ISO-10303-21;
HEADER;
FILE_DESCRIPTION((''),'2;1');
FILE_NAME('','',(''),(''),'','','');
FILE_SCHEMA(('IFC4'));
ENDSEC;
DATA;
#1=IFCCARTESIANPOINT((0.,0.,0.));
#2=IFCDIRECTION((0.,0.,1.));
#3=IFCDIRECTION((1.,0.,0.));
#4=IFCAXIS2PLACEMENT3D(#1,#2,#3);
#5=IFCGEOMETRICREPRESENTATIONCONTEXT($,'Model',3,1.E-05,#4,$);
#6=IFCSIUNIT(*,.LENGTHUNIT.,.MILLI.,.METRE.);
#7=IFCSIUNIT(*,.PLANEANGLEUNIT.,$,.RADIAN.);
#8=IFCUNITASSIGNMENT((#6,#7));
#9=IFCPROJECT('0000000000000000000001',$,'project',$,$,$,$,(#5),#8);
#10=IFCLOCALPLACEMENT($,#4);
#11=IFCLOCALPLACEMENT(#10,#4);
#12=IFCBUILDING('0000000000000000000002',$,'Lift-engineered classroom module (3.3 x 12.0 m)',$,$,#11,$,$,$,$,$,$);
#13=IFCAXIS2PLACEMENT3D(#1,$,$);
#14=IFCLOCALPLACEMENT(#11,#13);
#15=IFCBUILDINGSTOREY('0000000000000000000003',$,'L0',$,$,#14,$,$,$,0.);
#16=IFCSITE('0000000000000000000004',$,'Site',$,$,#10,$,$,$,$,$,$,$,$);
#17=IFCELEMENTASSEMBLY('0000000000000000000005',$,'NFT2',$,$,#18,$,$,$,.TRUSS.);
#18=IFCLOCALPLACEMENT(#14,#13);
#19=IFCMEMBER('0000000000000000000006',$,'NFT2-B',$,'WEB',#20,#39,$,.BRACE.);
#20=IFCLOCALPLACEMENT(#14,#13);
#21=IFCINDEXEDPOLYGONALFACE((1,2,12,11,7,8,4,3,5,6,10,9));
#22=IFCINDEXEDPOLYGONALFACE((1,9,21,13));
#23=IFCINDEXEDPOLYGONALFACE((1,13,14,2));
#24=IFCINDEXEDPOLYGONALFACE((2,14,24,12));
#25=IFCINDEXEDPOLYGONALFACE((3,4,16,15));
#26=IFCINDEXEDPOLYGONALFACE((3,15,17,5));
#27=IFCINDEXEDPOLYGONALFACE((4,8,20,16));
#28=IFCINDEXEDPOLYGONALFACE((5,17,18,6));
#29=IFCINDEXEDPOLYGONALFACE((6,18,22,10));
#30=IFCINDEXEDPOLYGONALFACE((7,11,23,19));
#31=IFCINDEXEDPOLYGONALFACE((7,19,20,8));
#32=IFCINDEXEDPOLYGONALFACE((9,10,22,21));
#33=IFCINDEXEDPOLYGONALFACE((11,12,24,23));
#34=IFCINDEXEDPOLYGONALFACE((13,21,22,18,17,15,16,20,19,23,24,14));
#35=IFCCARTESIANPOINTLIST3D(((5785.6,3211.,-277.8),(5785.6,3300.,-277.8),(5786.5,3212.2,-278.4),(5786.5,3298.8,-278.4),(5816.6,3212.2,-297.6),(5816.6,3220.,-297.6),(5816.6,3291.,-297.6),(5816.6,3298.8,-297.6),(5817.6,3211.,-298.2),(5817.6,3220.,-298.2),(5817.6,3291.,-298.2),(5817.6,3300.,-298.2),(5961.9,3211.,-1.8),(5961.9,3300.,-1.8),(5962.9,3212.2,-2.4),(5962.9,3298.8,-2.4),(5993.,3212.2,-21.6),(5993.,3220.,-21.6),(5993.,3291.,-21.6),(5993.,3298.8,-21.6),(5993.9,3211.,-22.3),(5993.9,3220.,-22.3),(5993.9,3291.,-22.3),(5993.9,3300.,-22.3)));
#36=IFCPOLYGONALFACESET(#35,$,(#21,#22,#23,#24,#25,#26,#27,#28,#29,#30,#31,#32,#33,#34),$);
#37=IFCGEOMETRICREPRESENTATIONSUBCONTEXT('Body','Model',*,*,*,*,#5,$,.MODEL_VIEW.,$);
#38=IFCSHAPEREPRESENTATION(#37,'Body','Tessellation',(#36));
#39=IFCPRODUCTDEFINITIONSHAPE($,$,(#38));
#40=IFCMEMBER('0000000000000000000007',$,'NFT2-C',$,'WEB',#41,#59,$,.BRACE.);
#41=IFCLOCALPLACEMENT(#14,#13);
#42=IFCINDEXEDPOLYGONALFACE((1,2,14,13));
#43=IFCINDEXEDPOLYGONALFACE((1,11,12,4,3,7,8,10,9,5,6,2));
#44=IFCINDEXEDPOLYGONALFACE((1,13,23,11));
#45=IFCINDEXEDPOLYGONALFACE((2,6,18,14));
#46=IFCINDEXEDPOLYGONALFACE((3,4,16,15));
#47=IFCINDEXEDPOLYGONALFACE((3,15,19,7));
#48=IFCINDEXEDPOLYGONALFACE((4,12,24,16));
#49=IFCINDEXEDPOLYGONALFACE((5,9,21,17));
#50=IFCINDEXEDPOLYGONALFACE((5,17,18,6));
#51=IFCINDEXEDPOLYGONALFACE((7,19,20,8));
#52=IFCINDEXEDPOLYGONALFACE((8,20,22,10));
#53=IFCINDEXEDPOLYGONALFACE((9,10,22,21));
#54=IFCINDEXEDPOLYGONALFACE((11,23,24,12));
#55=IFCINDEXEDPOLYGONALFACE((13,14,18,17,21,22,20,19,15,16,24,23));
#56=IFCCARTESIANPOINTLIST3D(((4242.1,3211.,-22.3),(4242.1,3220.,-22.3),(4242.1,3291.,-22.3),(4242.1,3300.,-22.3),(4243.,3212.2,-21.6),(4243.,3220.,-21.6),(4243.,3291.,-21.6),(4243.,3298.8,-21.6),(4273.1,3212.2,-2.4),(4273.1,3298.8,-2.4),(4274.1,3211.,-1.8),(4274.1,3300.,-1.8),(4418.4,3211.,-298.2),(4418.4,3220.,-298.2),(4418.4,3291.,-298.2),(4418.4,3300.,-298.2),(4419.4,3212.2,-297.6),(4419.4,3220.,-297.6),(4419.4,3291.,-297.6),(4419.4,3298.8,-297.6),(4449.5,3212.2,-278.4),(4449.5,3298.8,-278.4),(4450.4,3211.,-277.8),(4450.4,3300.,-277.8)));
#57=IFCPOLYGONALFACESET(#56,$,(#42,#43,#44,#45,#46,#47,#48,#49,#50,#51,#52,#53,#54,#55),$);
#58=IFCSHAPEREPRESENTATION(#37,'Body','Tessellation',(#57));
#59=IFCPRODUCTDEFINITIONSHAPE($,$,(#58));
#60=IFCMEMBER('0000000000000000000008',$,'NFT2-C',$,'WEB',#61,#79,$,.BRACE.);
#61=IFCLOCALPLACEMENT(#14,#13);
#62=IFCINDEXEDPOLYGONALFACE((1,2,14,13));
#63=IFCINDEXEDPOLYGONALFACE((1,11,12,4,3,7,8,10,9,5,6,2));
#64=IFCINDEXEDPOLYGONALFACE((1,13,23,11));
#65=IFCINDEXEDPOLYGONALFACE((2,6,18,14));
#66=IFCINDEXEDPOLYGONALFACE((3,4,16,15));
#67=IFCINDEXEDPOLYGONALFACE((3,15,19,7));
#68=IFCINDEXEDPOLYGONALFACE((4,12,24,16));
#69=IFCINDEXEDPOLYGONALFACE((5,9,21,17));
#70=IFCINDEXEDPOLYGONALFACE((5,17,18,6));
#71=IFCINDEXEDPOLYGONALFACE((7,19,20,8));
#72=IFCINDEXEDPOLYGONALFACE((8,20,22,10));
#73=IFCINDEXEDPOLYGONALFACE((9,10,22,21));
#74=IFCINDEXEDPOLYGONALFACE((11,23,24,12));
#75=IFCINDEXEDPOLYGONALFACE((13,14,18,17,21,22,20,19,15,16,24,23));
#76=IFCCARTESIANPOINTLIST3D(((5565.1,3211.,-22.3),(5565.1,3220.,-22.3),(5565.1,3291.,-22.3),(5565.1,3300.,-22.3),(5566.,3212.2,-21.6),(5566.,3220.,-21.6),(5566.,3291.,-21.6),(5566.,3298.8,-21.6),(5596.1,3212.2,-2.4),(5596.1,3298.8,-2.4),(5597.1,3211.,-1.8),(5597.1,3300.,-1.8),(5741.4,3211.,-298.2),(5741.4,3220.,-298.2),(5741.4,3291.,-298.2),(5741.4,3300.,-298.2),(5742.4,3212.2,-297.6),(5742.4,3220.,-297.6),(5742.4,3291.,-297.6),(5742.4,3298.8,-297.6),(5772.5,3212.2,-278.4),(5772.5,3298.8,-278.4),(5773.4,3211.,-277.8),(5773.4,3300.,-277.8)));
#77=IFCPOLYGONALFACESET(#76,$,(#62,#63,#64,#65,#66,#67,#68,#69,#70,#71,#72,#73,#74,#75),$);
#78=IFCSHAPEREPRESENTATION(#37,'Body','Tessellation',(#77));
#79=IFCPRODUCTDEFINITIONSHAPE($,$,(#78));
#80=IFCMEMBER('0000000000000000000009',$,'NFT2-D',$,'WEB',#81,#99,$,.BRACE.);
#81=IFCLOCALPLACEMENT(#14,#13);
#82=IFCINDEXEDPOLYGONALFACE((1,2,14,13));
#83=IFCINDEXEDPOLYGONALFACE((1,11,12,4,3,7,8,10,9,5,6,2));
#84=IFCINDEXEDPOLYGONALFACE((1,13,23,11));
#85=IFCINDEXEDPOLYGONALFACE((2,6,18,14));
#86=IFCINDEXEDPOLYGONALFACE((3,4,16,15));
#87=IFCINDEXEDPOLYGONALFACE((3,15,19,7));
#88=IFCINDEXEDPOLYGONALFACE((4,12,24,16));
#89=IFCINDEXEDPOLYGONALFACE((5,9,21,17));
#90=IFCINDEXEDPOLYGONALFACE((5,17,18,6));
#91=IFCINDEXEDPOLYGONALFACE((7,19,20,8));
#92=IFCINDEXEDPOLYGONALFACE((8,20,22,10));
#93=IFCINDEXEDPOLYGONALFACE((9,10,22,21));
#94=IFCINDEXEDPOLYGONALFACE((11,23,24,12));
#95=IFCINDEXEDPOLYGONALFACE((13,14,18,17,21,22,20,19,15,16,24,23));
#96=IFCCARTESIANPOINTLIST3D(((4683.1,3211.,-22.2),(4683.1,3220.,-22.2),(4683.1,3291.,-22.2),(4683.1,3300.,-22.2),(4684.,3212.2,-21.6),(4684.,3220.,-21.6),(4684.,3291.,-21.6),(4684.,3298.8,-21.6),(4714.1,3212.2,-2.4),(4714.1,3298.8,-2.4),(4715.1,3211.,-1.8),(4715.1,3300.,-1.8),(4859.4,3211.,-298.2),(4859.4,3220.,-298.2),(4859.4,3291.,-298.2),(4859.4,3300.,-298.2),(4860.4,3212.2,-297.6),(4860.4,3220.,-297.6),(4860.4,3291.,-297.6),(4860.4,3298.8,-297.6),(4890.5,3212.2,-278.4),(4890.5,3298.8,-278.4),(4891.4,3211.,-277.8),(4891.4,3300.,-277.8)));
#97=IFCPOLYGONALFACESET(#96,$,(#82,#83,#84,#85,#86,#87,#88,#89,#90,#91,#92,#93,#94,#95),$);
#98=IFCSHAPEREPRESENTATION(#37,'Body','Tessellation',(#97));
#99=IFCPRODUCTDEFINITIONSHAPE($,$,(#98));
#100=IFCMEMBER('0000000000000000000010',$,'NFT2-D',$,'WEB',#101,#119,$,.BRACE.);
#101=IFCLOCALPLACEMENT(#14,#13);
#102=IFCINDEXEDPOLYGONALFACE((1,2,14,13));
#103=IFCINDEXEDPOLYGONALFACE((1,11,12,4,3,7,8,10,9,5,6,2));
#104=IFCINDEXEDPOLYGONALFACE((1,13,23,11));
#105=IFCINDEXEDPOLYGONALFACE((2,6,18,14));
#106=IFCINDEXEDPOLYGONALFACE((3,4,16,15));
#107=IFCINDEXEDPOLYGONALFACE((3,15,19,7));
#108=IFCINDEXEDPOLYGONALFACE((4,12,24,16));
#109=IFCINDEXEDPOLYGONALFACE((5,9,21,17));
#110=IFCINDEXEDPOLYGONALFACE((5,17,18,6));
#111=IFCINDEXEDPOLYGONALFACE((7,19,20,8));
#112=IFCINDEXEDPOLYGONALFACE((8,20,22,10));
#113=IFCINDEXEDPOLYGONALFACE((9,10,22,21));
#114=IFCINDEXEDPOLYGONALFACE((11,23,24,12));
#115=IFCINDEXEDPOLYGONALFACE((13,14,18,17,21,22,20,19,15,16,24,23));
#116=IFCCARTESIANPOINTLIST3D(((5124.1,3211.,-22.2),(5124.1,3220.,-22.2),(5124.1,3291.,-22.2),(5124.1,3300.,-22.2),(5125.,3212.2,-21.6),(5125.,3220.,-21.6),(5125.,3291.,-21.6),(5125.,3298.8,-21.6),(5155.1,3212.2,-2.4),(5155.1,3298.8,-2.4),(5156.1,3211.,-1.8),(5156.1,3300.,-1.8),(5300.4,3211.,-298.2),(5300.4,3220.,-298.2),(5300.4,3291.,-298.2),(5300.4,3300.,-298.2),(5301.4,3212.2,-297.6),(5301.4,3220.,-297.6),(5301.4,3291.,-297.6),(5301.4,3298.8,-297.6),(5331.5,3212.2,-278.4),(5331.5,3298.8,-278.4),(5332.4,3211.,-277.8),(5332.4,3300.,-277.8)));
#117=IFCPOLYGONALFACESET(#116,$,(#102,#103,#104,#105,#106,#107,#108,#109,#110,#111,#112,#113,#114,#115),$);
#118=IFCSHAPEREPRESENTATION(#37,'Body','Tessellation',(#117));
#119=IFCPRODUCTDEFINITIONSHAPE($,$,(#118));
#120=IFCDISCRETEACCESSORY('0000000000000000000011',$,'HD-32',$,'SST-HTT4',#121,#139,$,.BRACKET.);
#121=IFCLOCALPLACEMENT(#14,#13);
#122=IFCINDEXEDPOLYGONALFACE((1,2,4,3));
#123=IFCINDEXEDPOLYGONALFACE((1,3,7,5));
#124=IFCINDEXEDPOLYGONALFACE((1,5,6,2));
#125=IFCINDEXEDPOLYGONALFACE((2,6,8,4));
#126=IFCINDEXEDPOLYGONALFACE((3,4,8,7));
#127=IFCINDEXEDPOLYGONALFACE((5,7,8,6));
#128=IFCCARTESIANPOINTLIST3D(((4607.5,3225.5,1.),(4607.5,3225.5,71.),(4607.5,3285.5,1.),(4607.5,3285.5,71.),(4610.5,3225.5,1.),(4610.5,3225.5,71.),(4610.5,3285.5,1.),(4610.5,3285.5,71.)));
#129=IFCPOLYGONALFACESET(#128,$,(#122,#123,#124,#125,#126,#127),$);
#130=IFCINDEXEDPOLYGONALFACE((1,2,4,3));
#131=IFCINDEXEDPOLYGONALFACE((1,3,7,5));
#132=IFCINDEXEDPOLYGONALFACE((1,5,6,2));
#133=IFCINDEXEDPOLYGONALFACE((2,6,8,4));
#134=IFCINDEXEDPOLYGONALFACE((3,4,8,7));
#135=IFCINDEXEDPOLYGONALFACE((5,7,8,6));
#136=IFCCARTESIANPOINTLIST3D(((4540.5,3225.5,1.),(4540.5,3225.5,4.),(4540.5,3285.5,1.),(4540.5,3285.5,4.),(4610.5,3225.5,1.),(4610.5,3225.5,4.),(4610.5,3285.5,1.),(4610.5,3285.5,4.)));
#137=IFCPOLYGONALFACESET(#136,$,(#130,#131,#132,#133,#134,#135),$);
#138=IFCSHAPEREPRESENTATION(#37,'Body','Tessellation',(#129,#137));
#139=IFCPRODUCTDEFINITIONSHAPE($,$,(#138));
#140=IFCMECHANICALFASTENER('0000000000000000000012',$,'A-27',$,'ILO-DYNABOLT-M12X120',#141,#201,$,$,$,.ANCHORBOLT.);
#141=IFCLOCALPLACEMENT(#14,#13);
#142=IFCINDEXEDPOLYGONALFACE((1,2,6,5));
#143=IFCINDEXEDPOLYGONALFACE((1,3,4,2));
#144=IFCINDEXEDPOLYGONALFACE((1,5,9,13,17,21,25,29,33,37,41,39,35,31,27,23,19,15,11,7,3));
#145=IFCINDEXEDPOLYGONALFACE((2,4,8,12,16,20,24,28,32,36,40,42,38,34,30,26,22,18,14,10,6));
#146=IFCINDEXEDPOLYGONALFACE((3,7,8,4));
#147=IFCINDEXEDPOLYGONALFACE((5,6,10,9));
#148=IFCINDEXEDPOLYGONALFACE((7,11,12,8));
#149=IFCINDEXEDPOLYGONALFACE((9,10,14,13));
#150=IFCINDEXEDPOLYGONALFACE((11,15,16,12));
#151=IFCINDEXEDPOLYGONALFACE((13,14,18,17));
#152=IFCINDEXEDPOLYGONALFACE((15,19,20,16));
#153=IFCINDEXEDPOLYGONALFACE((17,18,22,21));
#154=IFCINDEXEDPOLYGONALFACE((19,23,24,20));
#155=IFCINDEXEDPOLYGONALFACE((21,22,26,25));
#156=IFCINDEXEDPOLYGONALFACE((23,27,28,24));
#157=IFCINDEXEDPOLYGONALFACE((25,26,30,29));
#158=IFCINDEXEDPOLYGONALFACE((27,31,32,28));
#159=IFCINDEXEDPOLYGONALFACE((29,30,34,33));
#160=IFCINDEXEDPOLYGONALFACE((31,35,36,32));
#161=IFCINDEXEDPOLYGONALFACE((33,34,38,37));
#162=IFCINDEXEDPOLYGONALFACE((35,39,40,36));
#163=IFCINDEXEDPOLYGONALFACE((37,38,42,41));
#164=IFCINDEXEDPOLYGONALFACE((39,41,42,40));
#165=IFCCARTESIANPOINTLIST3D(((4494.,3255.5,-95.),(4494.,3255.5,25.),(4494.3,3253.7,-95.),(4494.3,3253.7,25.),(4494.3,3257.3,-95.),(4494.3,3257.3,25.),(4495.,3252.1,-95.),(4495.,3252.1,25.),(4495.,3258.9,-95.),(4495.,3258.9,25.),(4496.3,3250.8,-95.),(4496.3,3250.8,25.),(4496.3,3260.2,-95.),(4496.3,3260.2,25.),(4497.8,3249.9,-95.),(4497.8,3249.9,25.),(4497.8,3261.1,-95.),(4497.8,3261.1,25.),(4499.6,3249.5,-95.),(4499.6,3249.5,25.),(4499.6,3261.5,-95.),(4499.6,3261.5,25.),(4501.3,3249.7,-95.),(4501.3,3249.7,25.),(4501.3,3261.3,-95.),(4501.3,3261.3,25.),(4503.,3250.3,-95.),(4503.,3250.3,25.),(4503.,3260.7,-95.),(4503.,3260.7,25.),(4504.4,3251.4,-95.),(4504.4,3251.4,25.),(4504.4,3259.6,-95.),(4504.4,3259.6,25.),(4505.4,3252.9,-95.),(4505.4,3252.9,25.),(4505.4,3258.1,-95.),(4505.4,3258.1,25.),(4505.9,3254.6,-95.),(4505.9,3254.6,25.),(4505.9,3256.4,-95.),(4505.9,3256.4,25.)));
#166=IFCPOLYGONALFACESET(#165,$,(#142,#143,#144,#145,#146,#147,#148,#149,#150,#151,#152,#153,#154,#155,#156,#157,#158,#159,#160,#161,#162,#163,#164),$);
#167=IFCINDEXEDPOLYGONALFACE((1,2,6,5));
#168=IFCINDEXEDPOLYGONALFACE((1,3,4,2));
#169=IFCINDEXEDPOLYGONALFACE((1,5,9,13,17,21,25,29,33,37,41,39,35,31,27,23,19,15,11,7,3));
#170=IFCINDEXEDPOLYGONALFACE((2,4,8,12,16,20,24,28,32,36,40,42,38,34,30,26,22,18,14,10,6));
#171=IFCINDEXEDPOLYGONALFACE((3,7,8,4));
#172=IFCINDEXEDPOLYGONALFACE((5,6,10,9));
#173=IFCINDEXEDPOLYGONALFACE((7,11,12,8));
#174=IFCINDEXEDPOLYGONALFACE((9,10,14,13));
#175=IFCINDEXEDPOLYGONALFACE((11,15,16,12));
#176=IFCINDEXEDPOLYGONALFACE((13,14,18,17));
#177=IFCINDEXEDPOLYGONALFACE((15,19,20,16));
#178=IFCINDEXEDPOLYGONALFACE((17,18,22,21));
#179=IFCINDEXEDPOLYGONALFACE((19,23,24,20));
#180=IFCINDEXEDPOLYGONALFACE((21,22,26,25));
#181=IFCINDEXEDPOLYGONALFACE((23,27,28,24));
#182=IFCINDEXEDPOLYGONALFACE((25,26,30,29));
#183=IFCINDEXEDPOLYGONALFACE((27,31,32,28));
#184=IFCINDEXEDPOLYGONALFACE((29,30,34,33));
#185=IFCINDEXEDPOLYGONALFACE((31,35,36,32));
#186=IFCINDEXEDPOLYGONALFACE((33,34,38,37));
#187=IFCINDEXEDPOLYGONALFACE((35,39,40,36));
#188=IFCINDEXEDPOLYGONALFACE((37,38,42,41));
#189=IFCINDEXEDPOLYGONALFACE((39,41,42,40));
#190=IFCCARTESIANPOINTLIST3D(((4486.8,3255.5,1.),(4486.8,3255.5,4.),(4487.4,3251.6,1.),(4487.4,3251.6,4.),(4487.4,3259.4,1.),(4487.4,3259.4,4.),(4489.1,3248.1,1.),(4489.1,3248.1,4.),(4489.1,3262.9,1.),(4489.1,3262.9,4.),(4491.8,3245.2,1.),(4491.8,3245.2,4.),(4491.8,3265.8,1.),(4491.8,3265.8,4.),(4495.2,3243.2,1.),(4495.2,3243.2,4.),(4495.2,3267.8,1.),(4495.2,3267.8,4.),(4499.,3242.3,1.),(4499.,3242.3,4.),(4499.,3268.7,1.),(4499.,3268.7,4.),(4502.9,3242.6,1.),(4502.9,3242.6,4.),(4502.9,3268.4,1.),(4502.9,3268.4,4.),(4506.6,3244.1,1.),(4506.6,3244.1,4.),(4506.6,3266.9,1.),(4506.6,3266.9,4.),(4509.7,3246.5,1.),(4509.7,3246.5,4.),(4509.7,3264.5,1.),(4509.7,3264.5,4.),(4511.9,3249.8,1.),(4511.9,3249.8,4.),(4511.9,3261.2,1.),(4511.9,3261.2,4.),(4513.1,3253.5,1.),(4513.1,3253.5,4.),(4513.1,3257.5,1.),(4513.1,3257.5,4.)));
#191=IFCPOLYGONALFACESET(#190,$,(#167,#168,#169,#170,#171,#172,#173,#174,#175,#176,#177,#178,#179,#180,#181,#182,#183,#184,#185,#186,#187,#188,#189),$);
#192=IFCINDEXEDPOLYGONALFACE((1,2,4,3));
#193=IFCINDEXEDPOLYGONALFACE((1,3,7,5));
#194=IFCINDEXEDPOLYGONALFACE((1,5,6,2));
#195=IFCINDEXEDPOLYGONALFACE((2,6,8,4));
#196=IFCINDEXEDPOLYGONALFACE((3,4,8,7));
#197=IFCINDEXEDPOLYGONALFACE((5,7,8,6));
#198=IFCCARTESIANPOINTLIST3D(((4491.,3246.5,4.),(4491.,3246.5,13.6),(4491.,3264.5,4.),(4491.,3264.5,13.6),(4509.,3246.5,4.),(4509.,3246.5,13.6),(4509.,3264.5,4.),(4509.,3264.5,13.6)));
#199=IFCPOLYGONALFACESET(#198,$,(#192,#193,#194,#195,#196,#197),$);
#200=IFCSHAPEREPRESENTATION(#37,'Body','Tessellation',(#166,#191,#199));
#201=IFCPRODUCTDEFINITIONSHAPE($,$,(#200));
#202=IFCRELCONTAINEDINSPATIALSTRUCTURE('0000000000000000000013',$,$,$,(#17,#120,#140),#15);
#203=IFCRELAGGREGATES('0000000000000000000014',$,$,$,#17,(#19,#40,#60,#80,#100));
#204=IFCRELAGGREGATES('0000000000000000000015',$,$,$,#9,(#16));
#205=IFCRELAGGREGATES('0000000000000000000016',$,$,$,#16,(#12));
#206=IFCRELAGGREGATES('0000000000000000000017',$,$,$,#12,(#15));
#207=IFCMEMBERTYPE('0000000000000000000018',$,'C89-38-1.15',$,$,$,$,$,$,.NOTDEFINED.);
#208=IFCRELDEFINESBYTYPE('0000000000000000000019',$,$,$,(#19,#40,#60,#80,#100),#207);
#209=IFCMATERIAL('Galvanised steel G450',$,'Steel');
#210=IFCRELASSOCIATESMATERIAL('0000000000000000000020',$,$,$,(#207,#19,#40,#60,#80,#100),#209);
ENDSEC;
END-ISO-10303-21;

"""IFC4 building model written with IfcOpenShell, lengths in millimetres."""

from ifc_helpers import new_model, si_unit, frame, frame_2d, origin, origin_with_axes, origin_2d, place, context, subcontext, project, spatial, rectangle, circle, c_section, extrude, material, material_profile, profile_set, profile_usage, type_object, element, aggregate, save


model = new_model("IFC4")

# Units and contexts
model_context = context("Model", 3, precision=1e-05, world=origin_with_axes())
body_context = subcontext(model_context, "Body", "Model", "MODEL_VIEW")
ifc_project = project(units=[si_unit("LENGTHUNIT", "METRE", prefix="MILLI"), si_unit("PLANEANGLEUNIT", "RADIAN")], contexts=[model_context])

# Site, building, storey
site_placement = place(None, origin_with_axes())
site = spatial("IfcSite", under=ifc_project, at=site_placement, Name="Site")
building_placement = place(site_placement, origin_with_axes())
building = spatial("IfcBuilding", under=site, at=building_placement, Name="Lift-engineered classroom module (3.3 x 12.0 m)")
storey_placement = place(building_placement, origin())
storey = spatial("IfcBuildingStorey", under=building, at=storey_placement, Name="L0", Elevation=0.0)

# Element assembly, members
ifc_material = material(Name="Galvanised steel G450", Category="Steel")
assembly_1_placement = place(storey_placement, frame((0.0, 3255.5, -300.0)))
assembly_1 = element("IfcElementAssembly", 1, at=assembly_1_placement, inside=storey, Name="NFT2", PredefinedType="TRUSS")
ifc_material_profile_1 = material_profile(ifc_material, c_section(Depth=89.0, Width=38.0, WallThickness=1.1, Girth=9.0, at=origin_2d()), Name="C89-38-1.15")
ifc_profile_set_1 = profile_set([ifc_material_profile_1], Name="C89-38-1.15")
ifc_profile_usage_1 = profile_usage(ifc_profile_set_1)
member_type_1 = type_object("IfcMemberType", Name="C89-38-1.15", PredefinedType="NOTDEFINED", material=ifc_profile_set_1)
member_1_placement = place(assembly_1_placement, frame((5801.6, 0.0, 12.0), z_axis=(0.538459, 0.0, 0.842652), x_axis=(0.842652, 0.0, -0.538459)))
member_1 = element("IfcMember", 2, at=member_1_placement, type_object=member_type_1, material=ifc_profile_usage_1, Name="NFT2-B", ObjectType="WEB", PredefinedType="BRACE", context=body_context, shape_type="SweptSolid", body=[
    extrude(c_section(Depth=89.0, Width=38.0, WallThickness=1.1, Girth=9.0, at=origin_2d()), origin(), (0.0, 0.0, 1.0), 327.5),
])
member_2_placement = place(assembly_1_placement, frame((4434.4, 0.0, 12.0), z_axis=(-0.538459, 0.0, 0.842652), x_axis=(-0.842652, 0.0, -0.538459)))
member_2 = element("IfcMember", 3, at=member_2_placement, type_object=member_type_1, material=ifc_profile_usage_1, Name="NFT2-C", ObjectType="WEB", PredefinedType="BRACE", context=body_context, shape_type="SweptSolid", body=[
    extrude(c_section(Depth=89.0, Width=38.0, WallThickness=1.1, Girth=9.0, at=origin_2d()), origin(), (0.0, 0.0, 1.0), 327.5),
])
member_3_placement = place(assembly_1_placement, frame((5757.4, 0.0, 12.0), z_axis=(-0.538459, 0.0, 0.842652), x_axis=(-0.842652, 0.0, -0.538459)))
member_3 = element("IfcMember", 4, at=member_3_placement, type_object=member_type_1, material=ifc_profile_usage_1, Name="NFT2-C", ObjectType="WEB", PredefinedType="BRACE", context=body_context, shape_type="SweptSolid", body=[
    extrude(c_section(Depth=89.0, Width=38.0, WallThickness=1.1, Girth=9.0, at=origin_2d()), origin(), (0.0, 0.0, 1.0), 327.5),
])
member_4_placement = place(assembly_1_placement, frame((4875.4, 0.0, 12.0), z_axis=(-0.538437, 0.0, 0.842665), x_axis=(-0.842665, 0.0, -0.538437)))
member_4 = element("IfcMember", 5, at=member_4_placement, type_object=member_type_1, material=ifc_profile_usage_1, Name="NFT2-D", ObjectType="WEB", PredefinedType="BRACE", context=body_context, shape_type="SweptSolid", body=[
    extrude(c_section(Depth=89.0, Width=38.0, WallThickness=1.1, Girth=9.0, at=origin_2d()), origin(), (0.0, 0.0, 1.0), 327.5),
])
member_5_placement = place(assembly_1_placement, frame((5316.4, 0.0, 12.0), z_axis=(-0.538437, 0.0, 0.842665), x_axis=(-0.842665, 0.0, -0.538437)))
member_5 = element("IfcMember", 6, at=member_5_placement, type_object=member_type_1, material=ifc_profile_usage_1, Name="NFT2-D", ObjectType="WEB", PredefinedType="BRACE", context=body_context, shape_type="SweptSolid", body=[
    extrude(c_section(Depth=89.0, Width=38.0, WallThickness=1.1, Girth=9.0, at=origin_2d()), origin(), (0.0, 0.0, 1.0), 327.5),
])
aggregate(assembly_1, [member_1, member_2, member_3, member_4, member_5])

# Discrete accessory
discrete_accessory_1_placement = place(None, frame((4610.5, 3255.5, 0.0), z_axis=(0.0, 0.0, 1.0), x_axis=(-1.0, 0.0, 0.0)))
element("IfcDiscreteAccessory", 7, at=discrete_accessory_1_placement, inside=storey, Name="HD-32", ObjectType="SST-HTT4", PredefinedType="BRACKET", context=body_context, shape_type="SweptSolid", body=[
    extrude(rectangle(XDim=3.0, YDim=60.0, at=frame_2d((1.5, 0.0))), frame((0.0, 0.0, 1.0), z_axis=(0.0, 0.0, 1.0), x_axis=(1.0, 0.0, 0.0)), (0.0, 0.0, 1.0), 70.0),
    extrude(rectangle(XDim=70.0, YDim=60.0, at=frame_2d((35.0, 0.0))), frame((0.0, 0.0, 1.0), z_axis=(0.0, 0.0, 1.0), x_axis=(1.0, 0.0, 0.0)), (0.0, 0.0, 1.0), 3.0),
])

# Mechanical fastener
mechanical_fastener_placement = place(None, frame((4500.0, 3255.5, 0.0), z_axis=(0.0, 0.0, 1.0), x_axis=(-1.0, 0.0, 0.0)))
element("IfcMechanicalFastener", 8, at=mechanical_fastener_placement, inside=storey, Name="A-27", ObjectType="ILO-DYNABOLT-M12X120", PredefinedType="ANCHORBOLT", context=body_context, shape_type="SweptSolid", body=[
    extrude(circle(Radius=6.0, at=origin_2d()), frame((0.0, 0.0, -95.0), z_axis=(0.0, 0.0, 1.0), x_axis=(1.0, 0.0, 0.0)), (0.0, 0.0, 1.0), 120.0),
    extrude(circle(Radius=13.2, at=origin_2d()), frame((0.0, 0.0, 1.0), z_axis=(0.0, 0.0, 1.0), x_axis=(1.0, 0.0, 0.0)), (0.0, 0.0, 1.0), 3.0),
    extrude(rectangle(XDim=18.0, YDim=18.0, at=origin_2d()), frame((0.0, 0.0, 4.0), z_axis=(0.0, 0.0, 1.0), x_axis=(1.0, 0.0, 0.0)), (0.0, 0.0, 1.0), 9.6),
])

save(model, "model.ifc")
